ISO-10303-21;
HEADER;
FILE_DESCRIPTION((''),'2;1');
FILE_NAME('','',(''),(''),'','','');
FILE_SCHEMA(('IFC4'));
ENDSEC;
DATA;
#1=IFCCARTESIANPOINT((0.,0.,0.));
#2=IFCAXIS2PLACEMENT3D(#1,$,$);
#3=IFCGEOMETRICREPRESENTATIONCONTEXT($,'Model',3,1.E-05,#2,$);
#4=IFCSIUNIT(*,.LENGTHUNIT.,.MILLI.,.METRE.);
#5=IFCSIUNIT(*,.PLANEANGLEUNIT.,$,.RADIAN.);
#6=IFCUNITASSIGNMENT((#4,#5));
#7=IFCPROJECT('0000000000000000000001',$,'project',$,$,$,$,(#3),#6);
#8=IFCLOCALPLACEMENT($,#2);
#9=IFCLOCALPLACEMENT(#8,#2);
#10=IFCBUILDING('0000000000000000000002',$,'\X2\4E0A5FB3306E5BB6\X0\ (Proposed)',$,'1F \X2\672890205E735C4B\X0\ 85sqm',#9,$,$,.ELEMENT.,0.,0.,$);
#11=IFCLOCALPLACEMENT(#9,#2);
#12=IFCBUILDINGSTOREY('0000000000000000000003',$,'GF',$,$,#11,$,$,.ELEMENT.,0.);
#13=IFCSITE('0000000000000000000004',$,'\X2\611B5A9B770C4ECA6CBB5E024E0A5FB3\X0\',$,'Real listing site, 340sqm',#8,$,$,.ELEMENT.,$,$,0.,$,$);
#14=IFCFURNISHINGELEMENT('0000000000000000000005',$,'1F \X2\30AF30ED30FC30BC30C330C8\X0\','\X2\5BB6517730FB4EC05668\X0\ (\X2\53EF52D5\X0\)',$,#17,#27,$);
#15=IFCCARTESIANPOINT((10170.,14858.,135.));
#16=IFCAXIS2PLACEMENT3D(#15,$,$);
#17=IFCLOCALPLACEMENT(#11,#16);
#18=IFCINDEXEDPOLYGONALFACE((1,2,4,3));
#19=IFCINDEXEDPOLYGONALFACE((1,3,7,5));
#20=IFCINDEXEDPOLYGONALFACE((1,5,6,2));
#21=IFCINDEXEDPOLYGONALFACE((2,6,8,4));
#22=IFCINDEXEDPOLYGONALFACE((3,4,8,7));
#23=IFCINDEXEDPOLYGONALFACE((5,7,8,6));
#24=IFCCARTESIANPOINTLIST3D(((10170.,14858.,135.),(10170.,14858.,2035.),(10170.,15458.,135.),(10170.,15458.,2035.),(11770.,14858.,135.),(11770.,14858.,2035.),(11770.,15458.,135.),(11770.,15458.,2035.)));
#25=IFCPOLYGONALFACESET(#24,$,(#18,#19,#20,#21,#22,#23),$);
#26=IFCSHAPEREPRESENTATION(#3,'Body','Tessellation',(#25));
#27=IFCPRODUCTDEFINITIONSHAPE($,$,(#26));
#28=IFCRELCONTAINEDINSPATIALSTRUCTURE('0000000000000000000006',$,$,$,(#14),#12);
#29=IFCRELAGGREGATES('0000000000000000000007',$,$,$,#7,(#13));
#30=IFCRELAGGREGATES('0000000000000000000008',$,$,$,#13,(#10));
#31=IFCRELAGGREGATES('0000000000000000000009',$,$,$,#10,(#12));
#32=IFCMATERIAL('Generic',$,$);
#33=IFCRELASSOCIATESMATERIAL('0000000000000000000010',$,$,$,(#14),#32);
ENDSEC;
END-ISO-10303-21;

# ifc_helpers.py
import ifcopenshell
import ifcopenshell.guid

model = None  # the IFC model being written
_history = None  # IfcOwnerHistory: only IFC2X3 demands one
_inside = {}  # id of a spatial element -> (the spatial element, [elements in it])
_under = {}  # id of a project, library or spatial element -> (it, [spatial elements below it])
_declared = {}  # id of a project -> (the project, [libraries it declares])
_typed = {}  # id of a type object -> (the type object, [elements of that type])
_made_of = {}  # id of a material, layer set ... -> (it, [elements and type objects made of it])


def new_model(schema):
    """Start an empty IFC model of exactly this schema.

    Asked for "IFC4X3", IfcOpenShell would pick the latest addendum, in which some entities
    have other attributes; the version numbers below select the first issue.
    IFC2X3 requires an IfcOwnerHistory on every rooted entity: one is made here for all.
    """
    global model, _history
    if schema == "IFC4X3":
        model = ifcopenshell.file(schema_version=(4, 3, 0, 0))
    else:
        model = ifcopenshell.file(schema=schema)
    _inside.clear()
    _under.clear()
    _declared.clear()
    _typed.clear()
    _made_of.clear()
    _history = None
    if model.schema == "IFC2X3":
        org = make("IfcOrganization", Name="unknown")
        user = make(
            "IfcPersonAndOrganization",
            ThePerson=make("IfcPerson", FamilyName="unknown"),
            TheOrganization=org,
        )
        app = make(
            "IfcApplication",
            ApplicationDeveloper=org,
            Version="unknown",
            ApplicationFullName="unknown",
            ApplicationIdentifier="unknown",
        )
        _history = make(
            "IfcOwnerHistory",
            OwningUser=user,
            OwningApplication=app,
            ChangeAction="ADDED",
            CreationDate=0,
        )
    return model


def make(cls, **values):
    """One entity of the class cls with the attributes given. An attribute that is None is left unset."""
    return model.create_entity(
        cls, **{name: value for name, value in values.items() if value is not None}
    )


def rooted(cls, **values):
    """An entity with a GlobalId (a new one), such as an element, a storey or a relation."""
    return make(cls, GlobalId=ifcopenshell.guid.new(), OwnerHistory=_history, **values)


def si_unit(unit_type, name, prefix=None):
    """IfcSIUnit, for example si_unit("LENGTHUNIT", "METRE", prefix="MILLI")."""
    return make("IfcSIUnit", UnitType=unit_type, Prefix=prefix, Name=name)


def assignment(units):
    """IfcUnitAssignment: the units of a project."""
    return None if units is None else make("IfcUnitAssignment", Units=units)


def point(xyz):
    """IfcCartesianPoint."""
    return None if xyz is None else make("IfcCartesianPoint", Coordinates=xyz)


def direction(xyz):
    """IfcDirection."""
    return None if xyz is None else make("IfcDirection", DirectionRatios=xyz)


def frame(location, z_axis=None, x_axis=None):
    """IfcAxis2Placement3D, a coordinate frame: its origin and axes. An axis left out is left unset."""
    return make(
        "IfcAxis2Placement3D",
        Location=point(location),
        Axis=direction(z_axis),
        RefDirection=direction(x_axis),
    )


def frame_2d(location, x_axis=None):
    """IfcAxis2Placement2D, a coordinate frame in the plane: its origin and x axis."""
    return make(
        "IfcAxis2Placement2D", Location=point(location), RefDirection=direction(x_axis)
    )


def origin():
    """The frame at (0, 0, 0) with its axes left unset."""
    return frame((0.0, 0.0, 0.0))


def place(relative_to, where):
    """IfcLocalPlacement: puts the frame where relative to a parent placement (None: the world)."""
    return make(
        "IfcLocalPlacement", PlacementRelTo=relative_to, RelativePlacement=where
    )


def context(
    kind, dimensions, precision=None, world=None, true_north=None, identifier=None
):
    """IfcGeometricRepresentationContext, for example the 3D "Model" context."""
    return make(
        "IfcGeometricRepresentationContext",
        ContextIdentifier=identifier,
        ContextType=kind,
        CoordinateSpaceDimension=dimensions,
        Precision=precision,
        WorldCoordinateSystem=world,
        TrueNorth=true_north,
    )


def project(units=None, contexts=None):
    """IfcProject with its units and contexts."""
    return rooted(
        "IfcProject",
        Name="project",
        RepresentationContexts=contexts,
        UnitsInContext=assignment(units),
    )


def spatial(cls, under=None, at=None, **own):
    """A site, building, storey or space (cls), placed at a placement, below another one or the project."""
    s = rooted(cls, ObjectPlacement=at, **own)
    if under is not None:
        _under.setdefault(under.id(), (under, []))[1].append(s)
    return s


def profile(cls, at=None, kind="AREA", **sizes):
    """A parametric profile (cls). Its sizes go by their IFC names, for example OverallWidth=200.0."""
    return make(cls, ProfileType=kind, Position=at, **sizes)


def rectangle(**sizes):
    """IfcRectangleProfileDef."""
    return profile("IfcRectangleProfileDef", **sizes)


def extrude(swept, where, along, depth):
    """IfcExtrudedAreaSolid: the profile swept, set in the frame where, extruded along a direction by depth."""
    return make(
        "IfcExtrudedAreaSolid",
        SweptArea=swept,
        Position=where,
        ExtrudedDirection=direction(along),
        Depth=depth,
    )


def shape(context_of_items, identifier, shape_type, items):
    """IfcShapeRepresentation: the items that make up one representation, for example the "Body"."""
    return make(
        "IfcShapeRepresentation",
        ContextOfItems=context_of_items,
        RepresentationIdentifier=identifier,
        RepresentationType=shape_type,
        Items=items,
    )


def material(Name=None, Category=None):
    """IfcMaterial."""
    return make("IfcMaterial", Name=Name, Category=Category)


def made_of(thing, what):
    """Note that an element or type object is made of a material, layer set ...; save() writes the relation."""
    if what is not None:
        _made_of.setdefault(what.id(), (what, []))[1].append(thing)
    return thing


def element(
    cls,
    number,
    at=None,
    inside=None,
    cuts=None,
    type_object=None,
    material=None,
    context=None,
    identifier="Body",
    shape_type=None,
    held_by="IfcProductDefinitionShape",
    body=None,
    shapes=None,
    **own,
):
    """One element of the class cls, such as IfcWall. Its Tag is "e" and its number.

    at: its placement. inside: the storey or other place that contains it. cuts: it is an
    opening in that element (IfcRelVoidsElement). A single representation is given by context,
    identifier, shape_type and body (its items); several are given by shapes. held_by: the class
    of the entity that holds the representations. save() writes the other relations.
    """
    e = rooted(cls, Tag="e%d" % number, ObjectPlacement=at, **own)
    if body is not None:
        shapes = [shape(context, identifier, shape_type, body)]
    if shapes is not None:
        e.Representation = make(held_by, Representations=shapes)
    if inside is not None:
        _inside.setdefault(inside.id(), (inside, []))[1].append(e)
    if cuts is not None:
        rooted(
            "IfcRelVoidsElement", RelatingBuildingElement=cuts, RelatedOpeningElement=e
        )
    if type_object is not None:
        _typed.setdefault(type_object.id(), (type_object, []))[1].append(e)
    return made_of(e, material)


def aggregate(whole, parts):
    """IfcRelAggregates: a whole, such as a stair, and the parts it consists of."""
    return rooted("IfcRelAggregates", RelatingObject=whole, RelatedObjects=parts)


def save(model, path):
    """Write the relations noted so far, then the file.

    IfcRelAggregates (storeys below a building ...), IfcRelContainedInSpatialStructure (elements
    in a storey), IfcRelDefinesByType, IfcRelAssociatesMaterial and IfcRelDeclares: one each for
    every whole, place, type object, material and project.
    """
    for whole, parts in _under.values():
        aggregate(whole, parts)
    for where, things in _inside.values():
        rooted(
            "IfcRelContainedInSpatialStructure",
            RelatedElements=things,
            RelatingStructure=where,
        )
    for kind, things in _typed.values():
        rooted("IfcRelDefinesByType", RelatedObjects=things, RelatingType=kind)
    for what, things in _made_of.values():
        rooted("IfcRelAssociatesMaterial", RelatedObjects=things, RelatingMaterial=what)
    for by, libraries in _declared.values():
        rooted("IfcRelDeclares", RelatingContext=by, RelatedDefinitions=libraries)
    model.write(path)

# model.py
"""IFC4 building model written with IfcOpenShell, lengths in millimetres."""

from ifc_helpers import new_model, si_unit, frame, frame_2d, origin, place, context, project, spatial, rectangle, extrude, material, element, save


model = new_model("IFC4")

# Units and contexts
model_context = context("Model", 3, precision=1e-05, world=origin())
ifc_project = project(units=[si_unit("LENGTHUNIT", "METRE", prefix="MILLI"), si_unit("PLANEANGLEUNIT", "RADIAN")], contexts=[model_context])

# Site, building, storey
site_placement = place(None, origin())
site = spatial("IfcSite", under=ifc_project, at=site_placement, Name="愛媛県今治市上徳", ObjectType="Real listing site, 340sqm", CompositionType="ELEMENT", RefElevation=0.0)
building_placement = place(site_placement, origin())
building = spatial("IfcBuilding", under=site, at=building_placement, Name="上徳の家 (Proposed)", ObjectType="1F 木造平屋 85sqm", CompositionType="ELEMENT", ElevationOfRefHeight=0.0, ElevationOfTerrain=0.0)
storey_placement = place(building_placement, origin())
storey = spatial("IfcBuildingStorey", under=building, at=storey_placement, Name="GF", CompositionType="ELEMENT", Elevation=0.0)

# Shared definitions
ifc_material_1 = material(Name="Generic")

# Furnishing element
furnishing_placement = place(storey_placement, frame((10170.0, 14858.0, 135.0)))
element("IfcFurnishingElement", 1, at=furnishing_placement, inside=storey, material=ifc_material_1, Name="1F クローゼット", Description="家具・什器 (可動)", context=model_context, shape_type="SweptSolid", body=[
    extrude(rectangle(XDim=1600.0, YDim=600.0, at=frame_2d((800.0, 300.0))), frame((10170.0, 14858.0, 135.0)), (0.0, 0.0, 1.0), 1900.0),
])

save(model, "model.ifc")
